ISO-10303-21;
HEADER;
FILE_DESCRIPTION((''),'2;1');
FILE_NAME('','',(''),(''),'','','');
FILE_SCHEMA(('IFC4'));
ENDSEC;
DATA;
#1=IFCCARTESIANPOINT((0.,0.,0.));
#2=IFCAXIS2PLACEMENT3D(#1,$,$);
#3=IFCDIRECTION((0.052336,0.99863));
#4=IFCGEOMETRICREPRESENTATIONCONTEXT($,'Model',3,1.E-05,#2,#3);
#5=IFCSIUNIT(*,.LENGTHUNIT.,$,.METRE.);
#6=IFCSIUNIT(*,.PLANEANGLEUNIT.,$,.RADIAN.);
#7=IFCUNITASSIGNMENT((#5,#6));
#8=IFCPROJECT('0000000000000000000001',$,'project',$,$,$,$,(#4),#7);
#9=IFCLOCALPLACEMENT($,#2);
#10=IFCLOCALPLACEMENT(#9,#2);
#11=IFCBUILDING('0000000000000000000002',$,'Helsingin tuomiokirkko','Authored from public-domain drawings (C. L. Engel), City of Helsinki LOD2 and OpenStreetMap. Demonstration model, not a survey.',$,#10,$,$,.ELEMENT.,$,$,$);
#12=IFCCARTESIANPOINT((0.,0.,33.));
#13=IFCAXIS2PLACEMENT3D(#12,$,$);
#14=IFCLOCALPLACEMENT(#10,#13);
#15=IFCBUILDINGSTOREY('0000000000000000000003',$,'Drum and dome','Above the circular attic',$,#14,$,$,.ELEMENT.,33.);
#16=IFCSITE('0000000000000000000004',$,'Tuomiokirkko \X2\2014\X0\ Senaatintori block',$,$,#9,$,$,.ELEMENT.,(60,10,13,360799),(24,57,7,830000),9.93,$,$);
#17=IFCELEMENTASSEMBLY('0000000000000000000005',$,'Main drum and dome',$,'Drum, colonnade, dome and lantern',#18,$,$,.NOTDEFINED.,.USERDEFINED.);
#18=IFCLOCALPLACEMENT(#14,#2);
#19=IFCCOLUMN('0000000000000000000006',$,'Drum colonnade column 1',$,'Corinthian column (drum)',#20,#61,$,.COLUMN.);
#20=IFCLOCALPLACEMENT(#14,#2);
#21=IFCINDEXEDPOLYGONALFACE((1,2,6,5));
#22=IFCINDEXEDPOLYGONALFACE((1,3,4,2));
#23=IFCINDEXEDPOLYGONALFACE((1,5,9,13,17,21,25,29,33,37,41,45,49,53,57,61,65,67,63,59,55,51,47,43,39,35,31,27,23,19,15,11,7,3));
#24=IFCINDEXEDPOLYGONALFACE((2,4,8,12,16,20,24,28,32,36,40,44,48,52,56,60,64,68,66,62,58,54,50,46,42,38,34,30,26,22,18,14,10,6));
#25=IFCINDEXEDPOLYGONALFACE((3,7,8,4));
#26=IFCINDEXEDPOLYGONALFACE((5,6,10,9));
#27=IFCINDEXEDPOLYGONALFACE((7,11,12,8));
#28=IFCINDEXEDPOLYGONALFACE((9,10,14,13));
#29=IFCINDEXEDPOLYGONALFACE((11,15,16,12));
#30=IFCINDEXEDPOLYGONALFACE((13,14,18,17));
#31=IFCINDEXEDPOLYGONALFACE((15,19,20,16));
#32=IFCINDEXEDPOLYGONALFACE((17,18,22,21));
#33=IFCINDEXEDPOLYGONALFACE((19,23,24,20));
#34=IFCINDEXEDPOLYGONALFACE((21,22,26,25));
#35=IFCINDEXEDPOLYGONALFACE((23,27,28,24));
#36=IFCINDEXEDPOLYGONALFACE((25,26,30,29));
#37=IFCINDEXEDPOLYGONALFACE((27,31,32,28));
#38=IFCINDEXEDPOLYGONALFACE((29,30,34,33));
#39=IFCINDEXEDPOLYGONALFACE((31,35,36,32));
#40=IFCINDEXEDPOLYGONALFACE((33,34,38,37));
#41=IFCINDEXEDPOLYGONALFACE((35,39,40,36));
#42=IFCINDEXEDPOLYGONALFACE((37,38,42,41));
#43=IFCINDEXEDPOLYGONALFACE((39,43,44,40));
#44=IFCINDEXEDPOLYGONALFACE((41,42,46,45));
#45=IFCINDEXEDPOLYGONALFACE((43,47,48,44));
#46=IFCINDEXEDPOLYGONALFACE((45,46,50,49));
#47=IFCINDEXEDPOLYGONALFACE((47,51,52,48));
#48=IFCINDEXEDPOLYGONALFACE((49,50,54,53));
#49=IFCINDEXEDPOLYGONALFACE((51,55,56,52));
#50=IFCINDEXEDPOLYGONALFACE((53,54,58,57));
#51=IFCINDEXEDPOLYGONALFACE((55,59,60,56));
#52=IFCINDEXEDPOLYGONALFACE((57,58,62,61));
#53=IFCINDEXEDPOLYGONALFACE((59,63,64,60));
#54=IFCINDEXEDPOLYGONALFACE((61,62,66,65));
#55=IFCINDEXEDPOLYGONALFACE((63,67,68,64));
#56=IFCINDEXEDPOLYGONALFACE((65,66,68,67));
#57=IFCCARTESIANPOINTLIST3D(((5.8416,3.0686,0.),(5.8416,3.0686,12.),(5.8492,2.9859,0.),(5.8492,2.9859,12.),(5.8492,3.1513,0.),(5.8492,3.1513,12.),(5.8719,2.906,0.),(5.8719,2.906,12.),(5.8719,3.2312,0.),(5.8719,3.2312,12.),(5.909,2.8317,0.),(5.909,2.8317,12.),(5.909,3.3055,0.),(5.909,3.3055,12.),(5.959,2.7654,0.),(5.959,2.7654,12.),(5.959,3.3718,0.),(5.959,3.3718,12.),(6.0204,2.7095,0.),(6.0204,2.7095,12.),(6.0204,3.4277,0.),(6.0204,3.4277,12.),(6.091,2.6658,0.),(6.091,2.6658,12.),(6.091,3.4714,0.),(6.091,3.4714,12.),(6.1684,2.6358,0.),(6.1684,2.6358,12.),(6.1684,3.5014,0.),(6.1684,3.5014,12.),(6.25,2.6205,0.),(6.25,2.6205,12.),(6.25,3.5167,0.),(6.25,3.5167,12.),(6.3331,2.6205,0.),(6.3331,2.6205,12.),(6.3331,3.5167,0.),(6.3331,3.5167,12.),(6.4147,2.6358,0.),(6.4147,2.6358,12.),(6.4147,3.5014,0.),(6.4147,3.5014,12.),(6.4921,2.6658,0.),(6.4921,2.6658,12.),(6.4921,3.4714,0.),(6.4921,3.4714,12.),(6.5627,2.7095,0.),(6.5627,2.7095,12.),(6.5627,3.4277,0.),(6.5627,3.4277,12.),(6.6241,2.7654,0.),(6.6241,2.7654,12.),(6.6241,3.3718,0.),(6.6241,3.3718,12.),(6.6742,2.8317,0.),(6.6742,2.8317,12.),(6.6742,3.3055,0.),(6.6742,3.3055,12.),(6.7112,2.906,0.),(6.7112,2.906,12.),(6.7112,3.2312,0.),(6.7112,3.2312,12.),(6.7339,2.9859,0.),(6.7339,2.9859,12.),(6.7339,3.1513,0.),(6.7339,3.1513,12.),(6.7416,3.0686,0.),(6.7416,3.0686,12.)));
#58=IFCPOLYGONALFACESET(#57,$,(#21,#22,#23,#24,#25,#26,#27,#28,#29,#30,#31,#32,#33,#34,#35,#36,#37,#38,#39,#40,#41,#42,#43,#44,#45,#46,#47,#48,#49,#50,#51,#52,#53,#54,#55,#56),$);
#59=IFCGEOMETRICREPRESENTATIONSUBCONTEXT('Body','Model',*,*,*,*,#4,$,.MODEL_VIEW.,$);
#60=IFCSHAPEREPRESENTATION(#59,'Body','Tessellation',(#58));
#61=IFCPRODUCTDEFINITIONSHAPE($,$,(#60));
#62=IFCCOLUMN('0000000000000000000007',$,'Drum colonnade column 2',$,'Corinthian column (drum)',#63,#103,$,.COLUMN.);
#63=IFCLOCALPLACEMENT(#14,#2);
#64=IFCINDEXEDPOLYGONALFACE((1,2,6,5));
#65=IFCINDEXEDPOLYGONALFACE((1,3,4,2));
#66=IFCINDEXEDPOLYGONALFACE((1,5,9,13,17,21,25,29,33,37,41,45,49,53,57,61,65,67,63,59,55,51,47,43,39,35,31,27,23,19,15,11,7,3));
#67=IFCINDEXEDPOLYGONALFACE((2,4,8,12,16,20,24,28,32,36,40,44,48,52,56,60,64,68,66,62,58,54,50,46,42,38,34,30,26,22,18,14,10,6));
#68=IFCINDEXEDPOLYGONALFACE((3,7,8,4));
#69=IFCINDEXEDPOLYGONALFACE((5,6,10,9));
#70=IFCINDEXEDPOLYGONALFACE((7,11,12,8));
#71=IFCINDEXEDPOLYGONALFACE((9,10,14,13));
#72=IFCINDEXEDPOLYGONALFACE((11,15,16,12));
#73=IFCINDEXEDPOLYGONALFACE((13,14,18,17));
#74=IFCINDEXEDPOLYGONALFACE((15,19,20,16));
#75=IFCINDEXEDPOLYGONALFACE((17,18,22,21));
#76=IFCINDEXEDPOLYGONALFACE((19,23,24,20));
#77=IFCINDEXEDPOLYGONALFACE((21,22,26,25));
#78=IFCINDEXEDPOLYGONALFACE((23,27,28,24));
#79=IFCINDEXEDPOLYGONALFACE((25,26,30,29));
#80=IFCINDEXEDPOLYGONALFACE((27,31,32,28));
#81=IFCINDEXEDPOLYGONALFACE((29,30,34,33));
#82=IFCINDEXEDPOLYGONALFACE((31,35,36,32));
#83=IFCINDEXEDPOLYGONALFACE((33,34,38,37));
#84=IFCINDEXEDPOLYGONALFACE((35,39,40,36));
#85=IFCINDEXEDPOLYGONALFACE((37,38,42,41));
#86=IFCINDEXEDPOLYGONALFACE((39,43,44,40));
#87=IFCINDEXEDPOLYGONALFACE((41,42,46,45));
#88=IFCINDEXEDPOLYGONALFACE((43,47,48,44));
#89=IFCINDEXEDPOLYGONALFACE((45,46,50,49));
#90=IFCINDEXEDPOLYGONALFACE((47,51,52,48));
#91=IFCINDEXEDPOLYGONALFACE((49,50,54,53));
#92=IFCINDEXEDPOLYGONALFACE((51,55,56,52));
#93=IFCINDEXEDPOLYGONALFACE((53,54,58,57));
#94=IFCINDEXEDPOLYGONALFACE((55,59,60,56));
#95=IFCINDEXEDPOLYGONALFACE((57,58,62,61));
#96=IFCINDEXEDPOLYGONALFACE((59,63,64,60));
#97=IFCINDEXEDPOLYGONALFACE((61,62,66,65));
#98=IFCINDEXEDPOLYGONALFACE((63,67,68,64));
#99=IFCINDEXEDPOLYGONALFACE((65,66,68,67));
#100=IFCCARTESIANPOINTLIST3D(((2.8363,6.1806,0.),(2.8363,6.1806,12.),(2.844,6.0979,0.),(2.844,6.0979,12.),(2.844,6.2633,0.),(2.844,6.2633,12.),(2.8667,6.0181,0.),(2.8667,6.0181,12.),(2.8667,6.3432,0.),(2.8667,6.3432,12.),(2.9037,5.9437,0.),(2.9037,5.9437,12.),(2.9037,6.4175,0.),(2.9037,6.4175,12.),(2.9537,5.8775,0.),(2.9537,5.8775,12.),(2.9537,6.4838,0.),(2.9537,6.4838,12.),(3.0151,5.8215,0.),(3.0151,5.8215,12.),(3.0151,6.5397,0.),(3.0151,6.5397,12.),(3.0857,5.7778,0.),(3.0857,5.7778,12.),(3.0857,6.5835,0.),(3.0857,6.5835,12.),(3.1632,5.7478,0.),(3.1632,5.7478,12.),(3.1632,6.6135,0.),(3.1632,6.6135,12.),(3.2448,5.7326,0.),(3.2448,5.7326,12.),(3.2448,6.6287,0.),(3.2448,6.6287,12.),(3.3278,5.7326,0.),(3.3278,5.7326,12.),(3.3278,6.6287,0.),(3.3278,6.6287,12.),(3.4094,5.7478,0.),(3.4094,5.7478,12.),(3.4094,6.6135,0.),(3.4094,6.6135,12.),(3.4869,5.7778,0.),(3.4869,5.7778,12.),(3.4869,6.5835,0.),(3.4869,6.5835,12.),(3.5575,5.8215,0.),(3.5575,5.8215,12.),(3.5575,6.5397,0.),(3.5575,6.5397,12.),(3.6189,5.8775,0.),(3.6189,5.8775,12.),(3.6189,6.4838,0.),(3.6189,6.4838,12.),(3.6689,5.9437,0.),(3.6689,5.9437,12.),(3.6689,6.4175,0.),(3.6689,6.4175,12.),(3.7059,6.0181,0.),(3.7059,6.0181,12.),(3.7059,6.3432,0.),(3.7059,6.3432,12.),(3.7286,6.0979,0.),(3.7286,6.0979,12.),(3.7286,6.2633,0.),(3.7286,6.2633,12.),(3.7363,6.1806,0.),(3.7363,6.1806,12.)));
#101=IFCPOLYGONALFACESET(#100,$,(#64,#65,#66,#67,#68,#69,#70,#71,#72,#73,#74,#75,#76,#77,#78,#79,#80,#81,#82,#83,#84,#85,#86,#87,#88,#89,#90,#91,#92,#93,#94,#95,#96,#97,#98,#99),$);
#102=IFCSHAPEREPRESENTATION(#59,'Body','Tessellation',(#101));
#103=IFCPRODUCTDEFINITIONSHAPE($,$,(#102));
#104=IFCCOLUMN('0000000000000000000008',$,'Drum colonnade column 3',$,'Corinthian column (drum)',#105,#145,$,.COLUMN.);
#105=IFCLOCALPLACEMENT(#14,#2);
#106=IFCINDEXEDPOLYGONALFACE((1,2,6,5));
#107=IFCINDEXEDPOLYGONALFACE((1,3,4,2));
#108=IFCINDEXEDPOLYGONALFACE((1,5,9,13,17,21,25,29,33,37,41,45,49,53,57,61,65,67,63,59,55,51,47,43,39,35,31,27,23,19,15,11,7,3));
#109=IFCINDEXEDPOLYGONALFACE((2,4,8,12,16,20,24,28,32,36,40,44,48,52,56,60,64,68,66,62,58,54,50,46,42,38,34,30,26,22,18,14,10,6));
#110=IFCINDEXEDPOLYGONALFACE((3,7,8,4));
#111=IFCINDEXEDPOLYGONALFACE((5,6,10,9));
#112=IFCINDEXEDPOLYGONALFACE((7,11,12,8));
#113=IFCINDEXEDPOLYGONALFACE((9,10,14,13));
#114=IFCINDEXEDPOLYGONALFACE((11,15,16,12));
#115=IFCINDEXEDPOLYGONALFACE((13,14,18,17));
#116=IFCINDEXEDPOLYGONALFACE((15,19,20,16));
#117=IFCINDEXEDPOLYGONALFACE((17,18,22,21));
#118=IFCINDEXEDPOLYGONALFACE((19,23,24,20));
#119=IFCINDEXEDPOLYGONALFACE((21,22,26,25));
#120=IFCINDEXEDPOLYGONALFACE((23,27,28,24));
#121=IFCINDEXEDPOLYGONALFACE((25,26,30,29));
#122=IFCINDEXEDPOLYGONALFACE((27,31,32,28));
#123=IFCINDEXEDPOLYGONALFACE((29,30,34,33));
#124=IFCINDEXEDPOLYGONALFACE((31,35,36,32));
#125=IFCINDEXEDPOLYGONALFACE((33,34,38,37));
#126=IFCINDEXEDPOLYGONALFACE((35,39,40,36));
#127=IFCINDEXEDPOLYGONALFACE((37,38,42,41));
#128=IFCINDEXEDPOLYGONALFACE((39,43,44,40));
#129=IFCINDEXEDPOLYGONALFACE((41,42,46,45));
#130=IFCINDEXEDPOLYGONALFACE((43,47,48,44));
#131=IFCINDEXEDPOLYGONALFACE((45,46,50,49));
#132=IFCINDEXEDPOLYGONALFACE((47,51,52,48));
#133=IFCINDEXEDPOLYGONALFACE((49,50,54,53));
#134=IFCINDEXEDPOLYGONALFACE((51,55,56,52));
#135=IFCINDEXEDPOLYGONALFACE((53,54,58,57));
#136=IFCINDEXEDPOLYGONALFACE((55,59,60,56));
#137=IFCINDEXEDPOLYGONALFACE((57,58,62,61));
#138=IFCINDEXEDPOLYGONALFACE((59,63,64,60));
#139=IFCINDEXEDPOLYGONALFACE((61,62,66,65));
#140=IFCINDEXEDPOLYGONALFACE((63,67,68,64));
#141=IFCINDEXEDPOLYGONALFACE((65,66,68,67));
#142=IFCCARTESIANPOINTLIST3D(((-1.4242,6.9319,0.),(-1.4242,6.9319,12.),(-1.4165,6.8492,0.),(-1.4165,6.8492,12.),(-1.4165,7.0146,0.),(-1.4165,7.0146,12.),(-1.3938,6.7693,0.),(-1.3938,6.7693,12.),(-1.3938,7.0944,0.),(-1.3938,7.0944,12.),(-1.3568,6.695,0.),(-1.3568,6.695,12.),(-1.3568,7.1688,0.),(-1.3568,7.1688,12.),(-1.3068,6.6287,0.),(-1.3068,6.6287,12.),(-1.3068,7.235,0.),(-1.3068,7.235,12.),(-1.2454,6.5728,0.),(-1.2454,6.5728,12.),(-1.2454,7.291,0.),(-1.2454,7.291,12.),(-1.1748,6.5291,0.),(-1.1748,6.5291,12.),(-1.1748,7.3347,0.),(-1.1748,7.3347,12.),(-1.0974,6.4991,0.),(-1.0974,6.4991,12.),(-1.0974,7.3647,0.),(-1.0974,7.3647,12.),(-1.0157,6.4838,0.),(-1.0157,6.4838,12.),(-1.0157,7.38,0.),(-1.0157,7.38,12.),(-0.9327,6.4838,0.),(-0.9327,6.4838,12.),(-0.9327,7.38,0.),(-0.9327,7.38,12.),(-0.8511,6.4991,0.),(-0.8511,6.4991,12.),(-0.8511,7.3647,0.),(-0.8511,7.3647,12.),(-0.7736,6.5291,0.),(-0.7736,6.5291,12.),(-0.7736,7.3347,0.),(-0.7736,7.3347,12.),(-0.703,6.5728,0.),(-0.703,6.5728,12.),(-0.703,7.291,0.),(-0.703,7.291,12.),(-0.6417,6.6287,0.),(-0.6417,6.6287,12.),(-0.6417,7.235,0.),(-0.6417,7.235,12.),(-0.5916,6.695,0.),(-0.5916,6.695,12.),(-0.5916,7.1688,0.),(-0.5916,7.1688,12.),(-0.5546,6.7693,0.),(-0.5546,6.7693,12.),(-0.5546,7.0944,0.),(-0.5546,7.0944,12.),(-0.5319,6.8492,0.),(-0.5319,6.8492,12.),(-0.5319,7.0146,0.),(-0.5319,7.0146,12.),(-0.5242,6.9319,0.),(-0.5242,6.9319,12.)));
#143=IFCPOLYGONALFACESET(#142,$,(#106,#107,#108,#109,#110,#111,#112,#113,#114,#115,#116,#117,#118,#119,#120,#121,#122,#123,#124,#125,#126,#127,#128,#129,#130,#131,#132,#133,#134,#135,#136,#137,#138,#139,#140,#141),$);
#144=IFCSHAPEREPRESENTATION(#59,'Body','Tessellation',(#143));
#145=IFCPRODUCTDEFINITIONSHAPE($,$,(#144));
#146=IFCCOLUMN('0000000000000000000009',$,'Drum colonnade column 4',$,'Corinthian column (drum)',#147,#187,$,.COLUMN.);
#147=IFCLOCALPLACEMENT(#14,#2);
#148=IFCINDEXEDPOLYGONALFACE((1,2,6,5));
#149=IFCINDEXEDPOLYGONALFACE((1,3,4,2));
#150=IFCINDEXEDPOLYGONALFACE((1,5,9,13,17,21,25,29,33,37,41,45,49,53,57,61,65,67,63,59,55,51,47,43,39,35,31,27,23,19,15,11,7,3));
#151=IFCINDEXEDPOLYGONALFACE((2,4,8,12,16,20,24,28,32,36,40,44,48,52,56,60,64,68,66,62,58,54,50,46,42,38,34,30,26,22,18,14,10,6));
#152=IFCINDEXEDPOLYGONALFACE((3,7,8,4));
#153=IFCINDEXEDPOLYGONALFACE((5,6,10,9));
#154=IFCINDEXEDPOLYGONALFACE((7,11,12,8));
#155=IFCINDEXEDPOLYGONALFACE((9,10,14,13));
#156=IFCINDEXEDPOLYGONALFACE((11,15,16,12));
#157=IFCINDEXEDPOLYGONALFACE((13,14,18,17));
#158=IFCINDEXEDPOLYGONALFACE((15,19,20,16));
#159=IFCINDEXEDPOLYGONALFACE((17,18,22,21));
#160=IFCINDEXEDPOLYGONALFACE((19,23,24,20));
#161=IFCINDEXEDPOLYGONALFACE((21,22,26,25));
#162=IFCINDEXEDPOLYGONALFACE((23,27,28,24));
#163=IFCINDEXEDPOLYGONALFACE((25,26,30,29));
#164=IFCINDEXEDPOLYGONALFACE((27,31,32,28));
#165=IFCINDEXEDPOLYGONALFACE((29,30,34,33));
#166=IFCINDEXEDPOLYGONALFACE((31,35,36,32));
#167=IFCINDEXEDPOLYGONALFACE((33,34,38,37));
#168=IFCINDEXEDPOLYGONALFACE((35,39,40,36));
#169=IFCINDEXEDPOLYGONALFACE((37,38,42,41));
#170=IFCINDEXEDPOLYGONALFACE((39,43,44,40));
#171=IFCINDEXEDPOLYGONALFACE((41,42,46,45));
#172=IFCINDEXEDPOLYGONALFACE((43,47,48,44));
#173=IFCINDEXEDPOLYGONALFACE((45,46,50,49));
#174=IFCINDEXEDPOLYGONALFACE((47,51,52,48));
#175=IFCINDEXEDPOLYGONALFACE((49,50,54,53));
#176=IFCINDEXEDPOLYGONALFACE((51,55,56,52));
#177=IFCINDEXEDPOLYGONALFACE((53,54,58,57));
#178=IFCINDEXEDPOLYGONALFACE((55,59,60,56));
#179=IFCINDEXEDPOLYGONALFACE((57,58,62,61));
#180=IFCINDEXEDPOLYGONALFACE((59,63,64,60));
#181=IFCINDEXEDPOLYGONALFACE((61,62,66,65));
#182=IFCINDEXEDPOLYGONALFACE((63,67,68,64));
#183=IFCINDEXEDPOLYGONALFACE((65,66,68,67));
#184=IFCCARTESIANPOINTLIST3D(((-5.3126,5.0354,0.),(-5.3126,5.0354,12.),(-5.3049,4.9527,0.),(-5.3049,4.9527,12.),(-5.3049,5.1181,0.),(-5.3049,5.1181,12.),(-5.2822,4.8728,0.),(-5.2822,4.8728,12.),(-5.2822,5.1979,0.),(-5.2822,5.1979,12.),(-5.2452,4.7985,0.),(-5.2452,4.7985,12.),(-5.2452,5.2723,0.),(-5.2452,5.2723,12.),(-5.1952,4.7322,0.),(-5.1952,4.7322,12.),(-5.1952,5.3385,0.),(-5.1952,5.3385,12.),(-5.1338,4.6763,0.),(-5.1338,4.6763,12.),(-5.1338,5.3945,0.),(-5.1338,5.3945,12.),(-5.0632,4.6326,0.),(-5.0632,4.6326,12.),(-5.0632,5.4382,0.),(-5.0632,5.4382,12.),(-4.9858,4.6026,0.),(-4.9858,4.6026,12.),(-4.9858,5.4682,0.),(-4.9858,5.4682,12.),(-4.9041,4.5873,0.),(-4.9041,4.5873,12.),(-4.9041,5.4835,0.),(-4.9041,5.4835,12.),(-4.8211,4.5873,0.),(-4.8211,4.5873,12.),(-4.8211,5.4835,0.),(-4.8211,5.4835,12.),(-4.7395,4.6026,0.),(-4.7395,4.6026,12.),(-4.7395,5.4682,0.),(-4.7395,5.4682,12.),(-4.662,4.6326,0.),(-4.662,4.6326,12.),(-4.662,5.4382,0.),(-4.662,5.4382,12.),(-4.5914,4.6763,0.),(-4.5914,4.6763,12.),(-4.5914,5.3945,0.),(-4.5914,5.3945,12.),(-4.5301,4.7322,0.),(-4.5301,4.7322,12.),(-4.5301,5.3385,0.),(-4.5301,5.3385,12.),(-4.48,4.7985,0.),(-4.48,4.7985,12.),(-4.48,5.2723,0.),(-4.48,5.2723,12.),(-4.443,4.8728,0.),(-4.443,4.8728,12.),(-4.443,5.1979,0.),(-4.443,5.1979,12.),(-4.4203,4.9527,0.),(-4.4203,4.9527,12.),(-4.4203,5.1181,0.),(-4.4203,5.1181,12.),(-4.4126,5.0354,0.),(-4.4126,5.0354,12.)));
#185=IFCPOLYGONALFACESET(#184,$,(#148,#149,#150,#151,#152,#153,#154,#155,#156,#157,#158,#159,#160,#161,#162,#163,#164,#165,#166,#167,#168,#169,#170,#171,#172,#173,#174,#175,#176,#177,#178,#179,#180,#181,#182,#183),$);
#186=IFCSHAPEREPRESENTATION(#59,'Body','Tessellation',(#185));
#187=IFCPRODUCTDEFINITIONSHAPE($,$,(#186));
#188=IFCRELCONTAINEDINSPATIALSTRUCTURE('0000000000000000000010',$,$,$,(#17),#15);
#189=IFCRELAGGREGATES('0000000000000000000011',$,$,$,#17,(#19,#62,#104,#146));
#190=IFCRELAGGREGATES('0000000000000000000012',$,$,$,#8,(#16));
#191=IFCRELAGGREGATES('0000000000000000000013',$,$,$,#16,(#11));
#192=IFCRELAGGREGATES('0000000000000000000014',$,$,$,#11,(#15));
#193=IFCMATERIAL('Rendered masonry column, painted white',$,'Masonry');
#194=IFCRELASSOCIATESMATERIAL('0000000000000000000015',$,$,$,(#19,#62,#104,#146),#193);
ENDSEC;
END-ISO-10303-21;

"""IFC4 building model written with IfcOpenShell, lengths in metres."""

from ifc_helpers import new_model, si_unit, direction, frame, origin, origin_2d_with_axis, place, context, subcontext, project, spatial, circle, extrude, material, element, aggregate, save


model = new_model("IFC4")

# Units and contexts
model_context = context("Model", 3, precision=1e-05, world=origin(), true_north=direction((0.052336, 0.99863)))
body_context = subcontext(model_context, "Body", "Model", "MODEL_VIEW")
ifc_project = project(units=[si_unit("LENGTHUNIT", "METRE"), si_unit("PLANEANGLEUNIT", "RADIAN")], contexts=[model_context])

# Site, building, storey
site_placement = place(None, origin())
site = spatial("IfcSite", under=ifc_project, at=site_placement, Name="Tuomiokirkko — Senaatintori block", CompositionType="ELEMENT", RefLatitude=(60, 10, 13, 360799), RefLongitude=(24, 57, 7, 830000), RefElevation=9.93)
building_placement = place(site_placement, origin())
building = spatial("IfcBuilding", under=site, at=building_placement, Name="Helsingin tuomiokirkko", Description="Authored from public-domain drawings (C. L. Engel), City of Helsinki LOD2 and OpenStreetMap. Demonstration model, not a survey.", CompositionType="ELEMENT")
storey_placement = place(building_placement, frame((0.0, 0.0, 33.0)))
storey = spatial("IfcBuildingStorey", under=building, at=storey_placement, Name="Drum and dome", Description="Above the circular attic", CompositionType="ELEMENT", Elevation=33.0)

# Element assembly, columns
assembly_placement = place(building_placement, origin())
assembly = element("IfcElementAssembly", 1, at=assembly_placement, inside=storey, Name="Main drum and dome", ObjectType="Drum, colonnade, dome and lantern", AssemblyPlace="NOTDEFINED", PredefinedType="USERDEFINED")
ifc_material_1 = material(Name="Rendered masonry column, painted white", Category="Masonry")
column_1_placement = place(building_placement, origin())
column_1 = element("IfcColumn", 2, at=column_1_placement, material=ifc_material_1, Name="Drum colonnade column 1", ObjectType="Corinthian column (drum)", PredefinedType="COLUMN", context=body_context, shape_type="SweptSolid", body=[
    extrude(circle(Radius=0.45, at=origin_2d_with_axis()), frame((6.2916, 3.0686, 33.0)), (0.0, 0.0, 1.0), 12.0),
])
column_2_placement = place(building_placement, origin())
column_2 = element("IfcColumn", 3, at=column_2_placement, material=ifc_material_1, Name="Drum colonnade column 2", ObjectType="Corinthian column (drum)", PredefinedType="COLUMN", context=body_context, shape_type="SweptSolid", body=[
    extrude(circle(Radius=0.45, at=origin_2d_with_axis()), frame((3.2863, 6.1806, 33.0)), (0.0, 0.0, 1.0), 12.0),
])
column_3_placement = place(building_placement, origin())
column_3 = element("IfcColumn", 4, at=column_3_placement, material=ifc_material_1, Name="Drum colonnade column 3", ObjectType="Corinthian column (drum)", PredefinedType="COLUMN", context=body_context, shape_type="SweptSolid", body=[
    extrude(circle(Radius=0.45, at=origin_2d_with_axis()), frame((-0.9742, 6.9319, 33.0)), (0.0, 0.0, 1.0), 12.0),
])
column_4_placement = place(building_placement, origin())
column_4 = element("IfcColumn", 5, at=column_4_placement, material=ifc_material_1, Name="Drum colonnade column 4", ObjectType="Corinthian column (drum)", PredefinedType="COLUMN", context=body_context, shape_type="SweptSolid", body=[
    extrude(circle(Radius=0.45, at=origin_2d_with_axis()), frame((-4.8626, 5.0354, 33.0)), (0.0, 0.0, 1.0), 12.0),
])
aggregate(assembly, [column_1, column_2, column_3, column_4])

save(model, "model.ifc")
